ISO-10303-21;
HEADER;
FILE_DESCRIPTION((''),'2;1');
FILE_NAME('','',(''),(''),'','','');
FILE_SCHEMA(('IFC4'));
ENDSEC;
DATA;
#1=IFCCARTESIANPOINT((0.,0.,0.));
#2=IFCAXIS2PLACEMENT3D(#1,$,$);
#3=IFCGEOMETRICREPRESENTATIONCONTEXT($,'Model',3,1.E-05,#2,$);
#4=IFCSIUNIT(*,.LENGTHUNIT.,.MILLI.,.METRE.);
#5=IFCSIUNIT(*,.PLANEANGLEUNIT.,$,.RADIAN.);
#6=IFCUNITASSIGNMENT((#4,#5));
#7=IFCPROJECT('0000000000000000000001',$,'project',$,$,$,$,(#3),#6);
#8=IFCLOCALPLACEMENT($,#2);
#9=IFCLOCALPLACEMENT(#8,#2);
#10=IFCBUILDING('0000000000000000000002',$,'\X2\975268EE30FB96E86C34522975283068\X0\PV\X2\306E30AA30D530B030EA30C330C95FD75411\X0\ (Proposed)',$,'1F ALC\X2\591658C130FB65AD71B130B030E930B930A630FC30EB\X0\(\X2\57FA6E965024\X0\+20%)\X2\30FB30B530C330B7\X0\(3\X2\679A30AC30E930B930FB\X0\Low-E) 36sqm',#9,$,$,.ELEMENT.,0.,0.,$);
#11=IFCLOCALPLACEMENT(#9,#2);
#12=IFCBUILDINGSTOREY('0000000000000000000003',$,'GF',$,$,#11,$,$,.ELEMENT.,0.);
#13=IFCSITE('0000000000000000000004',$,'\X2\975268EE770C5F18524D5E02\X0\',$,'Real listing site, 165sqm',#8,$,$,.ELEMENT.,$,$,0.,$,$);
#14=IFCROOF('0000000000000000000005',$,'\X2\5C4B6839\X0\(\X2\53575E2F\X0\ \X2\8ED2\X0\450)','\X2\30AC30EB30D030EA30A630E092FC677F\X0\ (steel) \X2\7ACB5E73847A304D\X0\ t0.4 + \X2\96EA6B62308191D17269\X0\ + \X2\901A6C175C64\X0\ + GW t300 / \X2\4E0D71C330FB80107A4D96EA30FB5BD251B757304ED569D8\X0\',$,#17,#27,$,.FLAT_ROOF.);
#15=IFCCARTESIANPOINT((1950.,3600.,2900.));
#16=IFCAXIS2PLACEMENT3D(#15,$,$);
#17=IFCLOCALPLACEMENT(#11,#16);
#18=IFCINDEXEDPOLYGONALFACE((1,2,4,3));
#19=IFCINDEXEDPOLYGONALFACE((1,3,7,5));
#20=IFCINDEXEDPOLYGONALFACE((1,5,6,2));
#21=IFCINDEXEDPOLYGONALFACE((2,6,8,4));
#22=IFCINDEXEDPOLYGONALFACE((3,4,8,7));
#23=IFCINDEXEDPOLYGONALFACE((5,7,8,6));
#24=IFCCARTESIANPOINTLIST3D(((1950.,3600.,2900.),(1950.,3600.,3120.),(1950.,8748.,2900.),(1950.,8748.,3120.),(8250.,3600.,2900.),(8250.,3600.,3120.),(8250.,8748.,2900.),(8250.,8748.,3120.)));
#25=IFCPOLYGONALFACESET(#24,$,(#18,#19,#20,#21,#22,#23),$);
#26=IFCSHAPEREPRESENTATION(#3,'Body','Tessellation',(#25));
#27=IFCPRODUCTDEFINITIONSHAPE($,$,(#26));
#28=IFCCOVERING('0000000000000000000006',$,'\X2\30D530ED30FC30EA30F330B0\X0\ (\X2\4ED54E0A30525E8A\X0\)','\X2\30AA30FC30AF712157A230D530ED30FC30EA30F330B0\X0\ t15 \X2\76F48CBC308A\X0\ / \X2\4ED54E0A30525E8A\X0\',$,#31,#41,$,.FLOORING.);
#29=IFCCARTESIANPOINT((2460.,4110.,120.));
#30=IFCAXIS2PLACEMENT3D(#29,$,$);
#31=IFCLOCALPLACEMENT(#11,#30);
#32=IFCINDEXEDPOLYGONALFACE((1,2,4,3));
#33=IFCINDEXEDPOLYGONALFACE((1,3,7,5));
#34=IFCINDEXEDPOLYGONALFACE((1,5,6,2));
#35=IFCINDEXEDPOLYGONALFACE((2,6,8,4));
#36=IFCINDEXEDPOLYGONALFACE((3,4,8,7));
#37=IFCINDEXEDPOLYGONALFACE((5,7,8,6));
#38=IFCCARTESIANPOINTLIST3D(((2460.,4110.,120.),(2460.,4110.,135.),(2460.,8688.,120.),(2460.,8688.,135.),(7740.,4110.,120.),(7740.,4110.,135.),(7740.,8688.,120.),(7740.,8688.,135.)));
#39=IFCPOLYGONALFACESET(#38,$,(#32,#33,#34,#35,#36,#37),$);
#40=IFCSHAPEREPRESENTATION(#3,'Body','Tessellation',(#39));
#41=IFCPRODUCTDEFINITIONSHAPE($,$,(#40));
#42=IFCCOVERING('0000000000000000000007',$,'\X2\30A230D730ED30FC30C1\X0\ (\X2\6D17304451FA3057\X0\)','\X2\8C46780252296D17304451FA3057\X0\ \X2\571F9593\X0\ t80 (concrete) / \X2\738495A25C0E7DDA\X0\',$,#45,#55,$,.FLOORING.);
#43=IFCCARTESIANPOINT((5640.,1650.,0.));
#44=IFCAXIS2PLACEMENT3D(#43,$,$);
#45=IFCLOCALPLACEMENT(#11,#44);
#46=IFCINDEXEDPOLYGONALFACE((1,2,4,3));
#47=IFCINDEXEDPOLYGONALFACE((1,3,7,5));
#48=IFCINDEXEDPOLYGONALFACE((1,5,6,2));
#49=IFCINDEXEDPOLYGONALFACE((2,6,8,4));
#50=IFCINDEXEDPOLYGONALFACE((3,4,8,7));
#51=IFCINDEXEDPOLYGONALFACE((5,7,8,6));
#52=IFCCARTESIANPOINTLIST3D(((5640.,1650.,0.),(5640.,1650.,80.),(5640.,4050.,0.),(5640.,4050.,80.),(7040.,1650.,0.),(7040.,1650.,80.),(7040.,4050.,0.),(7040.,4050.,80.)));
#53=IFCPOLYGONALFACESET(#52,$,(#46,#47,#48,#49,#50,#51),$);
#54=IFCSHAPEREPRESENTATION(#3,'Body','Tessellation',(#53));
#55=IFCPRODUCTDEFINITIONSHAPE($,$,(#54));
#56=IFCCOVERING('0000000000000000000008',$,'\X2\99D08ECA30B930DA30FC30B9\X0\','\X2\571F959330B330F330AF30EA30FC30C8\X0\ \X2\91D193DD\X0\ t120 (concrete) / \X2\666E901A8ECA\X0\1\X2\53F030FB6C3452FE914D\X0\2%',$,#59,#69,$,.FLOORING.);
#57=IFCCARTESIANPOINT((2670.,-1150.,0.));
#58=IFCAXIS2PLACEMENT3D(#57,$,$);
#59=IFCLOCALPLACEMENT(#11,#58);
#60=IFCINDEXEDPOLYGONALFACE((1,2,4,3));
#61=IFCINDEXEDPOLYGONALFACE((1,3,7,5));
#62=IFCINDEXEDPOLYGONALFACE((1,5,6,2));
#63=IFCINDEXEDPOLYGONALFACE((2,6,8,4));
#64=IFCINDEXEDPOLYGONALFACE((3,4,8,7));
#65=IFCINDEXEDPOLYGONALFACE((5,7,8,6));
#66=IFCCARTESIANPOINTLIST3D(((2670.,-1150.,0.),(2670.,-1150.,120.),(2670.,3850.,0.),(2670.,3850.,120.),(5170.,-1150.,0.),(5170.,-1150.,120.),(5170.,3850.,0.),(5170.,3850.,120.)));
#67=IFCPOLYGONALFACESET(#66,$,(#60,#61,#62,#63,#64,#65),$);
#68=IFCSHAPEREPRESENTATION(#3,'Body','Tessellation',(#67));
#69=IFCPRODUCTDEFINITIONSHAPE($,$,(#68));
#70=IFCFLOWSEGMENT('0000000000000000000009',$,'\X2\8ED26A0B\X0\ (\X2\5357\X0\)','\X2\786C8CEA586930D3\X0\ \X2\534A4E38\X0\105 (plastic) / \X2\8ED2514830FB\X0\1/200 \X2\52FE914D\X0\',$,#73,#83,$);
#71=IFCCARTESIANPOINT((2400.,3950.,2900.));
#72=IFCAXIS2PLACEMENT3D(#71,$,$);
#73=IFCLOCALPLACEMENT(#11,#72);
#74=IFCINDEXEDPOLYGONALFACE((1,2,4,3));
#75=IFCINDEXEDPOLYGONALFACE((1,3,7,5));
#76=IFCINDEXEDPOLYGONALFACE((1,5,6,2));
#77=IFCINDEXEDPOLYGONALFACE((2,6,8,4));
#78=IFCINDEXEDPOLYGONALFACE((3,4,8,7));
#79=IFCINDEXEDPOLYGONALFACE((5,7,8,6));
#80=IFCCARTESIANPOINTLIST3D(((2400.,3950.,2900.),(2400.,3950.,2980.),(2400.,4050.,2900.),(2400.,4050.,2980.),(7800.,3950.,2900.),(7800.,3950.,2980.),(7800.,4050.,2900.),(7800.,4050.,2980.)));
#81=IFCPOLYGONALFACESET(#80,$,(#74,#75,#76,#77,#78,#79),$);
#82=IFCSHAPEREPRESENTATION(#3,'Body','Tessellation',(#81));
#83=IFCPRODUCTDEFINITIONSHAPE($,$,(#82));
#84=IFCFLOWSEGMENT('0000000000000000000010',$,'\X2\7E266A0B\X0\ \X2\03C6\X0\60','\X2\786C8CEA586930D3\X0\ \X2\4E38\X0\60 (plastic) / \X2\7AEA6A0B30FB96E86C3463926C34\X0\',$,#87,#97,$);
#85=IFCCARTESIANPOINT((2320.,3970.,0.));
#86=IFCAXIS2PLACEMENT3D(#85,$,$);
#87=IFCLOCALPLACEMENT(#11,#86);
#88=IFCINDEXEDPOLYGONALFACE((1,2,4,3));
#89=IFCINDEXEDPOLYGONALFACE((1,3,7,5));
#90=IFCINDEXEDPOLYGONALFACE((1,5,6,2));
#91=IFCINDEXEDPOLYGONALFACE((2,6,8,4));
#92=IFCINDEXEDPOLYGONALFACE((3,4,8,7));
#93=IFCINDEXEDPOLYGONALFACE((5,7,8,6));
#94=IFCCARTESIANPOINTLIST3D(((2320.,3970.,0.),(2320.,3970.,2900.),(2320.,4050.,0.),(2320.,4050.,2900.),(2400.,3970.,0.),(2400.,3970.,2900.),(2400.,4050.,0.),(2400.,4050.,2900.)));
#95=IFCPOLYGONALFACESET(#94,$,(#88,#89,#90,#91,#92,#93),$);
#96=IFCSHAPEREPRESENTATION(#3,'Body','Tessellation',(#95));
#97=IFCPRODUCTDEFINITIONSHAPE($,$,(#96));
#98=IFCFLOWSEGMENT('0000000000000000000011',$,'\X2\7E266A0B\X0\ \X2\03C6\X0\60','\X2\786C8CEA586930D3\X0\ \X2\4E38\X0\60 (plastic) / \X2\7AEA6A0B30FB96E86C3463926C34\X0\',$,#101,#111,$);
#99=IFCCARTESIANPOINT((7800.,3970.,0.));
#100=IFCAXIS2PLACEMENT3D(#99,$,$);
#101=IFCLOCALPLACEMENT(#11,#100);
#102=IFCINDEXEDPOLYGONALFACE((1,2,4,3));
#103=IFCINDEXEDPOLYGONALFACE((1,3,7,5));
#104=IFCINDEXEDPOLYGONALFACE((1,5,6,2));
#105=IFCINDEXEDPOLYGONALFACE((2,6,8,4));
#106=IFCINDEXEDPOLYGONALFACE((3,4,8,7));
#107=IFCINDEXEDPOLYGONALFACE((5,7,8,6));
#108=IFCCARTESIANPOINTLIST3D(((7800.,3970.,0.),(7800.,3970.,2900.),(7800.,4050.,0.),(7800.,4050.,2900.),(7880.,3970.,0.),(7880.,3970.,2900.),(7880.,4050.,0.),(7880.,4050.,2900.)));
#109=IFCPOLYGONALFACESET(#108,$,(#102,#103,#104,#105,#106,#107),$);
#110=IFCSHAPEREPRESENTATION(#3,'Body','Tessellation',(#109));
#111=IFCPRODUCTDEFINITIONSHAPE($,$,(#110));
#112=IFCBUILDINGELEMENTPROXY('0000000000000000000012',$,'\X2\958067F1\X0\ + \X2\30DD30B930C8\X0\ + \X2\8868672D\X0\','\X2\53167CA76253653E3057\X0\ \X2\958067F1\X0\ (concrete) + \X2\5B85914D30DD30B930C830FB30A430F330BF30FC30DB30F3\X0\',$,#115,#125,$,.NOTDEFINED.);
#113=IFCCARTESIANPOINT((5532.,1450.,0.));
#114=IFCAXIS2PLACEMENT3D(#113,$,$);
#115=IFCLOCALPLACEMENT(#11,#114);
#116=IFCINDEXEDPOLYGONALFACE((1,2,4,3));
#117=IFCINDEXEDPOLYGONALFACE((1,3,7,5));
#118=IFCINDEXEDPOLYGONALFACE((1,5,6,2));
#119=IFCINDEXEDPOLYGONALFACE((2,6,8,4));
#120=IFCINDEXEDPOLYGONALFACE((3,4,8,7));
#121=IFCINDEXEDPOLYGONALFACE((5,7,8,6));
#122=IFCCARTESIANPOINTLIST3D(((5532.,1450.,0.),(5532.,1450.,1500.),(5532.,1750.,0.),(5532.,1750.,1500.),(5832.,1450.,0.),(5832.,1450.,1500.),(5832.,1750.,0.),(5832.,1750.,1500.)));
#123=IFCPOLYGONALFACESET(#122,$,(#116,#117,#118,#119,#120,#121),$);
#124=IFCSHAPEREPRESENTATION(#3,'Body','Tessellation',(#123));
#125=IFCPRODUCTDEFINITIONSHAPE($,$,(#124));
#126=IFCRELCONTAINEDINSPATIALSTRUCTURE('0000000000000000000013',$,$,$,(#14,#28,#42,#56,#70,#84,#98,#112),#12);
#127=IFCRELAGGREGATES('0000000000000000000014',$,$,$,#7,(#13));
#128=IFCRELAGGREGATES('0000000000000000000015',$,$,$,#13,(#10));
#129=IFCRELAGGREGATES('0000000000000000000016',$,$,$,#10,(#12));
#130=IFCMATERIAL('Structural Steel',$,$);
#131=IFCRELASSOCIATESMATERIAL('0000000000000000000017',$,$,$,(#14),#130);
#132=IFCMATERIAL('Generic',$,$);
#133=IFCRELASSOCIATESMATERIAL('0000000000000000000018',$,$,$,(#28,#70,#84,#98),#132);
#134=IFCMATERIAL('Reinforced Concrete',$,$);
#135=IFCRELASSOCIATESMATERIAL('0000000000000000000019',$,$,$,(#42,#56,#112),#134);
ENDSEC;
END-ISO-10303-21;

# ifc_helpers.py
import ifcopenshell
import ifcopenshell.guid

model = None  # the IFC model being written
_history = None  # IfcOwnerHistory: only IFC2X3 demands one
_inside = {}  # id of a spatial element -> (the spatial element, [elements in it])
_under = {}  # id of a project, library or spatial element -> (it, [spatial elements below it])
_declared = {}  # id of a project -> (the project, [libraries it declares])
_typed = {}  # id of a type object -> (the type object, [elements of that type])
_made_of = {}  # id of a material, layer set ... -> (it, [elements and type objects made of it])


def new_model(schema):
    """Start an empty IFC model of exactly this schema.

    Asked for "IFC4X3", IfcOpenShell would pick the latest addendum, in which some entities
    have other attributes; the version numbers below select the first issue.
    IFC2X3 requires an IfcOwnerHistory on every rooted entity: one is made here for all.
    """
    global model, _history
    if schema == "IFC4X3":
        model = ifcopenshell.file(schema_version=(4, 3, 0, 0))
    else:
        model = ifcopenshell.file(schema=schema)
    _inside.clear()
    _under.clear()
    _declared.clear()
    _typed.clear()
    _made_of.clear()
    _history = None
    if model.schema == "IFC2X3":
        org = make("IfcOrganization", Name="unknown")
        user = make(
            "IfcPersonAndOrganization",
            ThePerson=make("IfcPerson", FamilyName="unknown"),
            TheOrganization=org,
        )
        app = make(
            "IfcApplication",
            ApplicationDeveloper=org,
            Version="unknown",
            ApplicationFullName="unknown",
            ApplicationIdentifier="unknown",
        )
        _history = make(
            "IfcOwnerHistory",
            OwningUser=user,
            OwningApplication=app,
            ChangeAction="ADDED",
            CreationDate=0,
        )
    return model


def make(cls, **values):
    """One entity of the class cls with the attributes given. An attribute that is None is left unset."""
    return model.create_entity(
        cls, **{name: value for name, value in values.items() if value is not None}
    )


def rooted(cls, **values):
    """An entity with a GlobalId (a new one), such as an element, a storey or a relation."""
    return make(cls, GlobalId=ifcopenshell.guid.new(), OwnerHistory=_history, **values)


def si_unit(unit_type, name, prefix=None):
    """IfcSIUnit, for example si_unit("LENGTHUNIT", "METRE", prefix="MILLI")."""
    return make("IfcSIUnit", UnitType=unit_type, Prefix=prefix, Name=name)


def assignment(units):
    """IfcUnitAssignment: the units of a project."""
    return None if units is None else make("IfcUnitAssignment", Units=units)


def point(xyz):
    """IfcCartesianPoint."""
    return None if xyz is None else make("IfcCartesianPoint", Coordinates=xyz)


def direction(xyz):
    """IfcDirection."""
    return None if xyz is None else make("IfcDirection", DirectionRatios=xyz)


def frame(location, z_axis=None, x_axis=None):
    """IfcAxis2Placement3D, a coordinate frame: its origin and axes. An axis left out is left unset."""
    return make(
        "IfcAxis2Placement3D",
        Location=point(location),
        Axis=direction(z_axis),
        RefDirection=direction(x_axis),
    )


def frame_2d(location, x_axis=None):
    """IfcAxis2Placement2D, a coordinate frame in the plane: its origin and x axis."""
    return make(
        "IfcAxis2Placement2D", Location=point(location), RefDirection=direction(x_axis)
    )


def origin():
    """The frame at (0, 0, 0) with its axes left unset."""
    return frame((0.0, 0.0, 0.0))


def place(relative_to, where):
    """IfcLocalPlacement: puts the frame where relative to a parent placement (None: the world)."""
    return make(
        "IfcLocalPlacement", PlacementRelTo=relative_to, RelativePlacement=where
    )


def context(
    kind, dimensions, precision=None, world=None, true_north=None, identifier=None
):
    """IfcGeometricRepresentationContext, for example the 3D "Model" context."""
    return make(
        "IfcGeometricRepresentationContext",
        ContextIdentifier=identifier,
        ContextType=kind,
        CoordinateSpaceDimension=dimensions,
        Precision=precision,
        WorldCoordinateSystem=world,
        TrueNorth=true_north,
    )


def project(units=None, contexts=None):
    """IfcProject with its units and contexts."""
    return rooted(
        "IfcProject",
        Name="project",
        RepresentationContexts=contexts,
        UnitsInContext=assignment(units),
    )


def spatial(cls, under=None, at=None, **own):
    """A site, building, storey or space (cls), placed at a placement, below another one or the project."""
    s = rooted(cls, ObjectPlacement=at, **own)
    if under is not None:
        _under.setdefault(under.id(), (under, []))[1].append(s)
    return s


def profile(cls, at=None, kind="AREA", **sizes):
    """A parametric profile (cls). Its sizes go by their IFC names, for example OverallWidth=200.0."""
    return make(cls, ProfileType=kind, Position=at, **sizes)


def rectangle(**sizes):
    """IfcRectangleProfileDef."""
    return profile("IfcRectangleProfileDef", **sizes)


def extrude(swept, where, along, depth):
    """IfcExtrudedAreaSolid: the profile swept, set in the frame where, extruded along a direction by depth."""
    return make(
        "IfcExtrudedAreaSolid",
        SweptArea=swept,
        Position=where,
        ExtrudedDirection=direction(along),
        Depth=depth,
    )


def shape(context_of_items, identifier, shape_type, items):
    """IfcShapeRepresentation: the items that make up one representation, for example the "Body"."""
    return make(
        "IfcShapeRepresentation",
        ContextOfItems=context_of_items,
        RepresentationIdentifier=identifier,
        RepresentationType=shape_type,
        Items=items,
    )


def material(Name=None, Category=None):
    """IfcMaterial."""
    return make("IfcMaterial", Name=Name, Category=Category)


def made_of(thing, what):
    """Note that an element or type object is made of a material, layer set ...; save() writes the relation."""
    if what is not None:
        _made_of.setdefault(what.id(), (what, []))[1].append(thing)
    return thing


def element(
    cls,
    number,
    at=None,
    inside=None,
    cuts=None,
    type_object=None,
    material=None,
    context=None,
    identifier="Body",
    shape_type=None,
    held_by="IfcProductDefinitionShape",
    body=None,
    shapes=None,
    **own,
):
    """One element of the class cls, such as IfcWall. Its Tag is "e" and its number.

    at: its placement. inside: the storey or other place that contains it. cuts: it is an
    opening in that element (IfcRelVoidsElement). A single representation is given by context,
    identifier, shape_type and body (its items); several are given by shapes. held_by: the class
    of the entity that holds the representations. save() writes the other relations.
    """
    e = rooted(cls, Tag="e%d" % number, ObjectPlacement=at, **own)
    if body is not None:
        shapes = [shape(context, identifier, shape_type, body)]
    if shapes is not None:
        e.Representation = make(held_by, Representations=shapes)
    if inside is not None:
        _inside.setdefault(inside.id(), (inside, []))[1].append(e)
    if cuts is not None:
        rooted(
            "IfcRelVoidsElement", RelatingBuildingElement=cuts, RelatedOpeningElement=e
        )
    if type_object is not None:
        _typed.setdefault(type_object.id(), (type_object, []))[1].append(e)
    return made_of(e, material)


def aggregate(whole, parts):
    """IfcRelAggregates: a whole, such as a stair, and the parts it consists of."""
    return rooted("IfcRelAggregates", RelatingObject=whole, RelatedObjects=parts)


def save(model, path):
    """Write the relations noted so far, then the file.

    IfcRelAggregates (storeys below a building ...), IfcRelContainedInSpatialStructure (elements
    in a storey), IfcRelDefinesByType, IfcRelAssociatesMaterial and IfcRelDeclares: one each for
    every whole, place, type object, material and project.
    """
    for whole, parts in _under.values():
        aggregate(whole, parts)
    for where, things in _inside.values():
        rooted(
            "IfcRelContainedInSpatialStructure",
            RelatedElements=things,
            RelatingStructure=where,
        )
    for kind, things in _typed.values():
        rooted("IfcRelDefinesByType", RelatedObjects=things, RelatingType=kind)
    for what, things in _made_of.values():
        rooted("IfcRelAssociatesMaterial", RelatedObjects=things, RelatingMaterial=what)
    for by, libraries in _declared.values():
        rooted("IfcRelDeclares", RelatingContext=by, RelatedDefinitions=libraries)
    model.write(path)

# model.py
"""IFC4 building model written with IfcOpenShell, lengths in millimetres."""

from ifc_helpers import new_model, si_unit, frame, frame_2d, origin, place, context, project, spatial, rectangle, extrude, material, element, save


model = new_model("IFC4")

# Units and contexts
model_context = context("Model", 3, precision=1e-05, world=origin())
ifc_project = project(units=[si_unit("LENGTHUNIT", "METRE", prefix="MILLI"), si_unit("PLANEANGLEUNIT", "RADIAN")], contexts=[model_context])

# Site, building, storey
site_placement = place(None, origin())
site = spatial("IfcSite", under=ifc_project, at=site_placement, Name="青森県弘前市", ObjectType="Real listing site, 165sqm", CompositionType="ELEMENT", RefElevation=0.0)
building_placement = place(site_placement, origin())
building = spatial("IfcBuilding", under=site, at=building_placement, Name="青森・雨水利用とPVのオフグリッド志向 (Proposed)", ObjectType="1F ALC外壁・断熱グラスウール(基準値+20%)・サッシ(3枚ガラス・Low-E) 36sqm", CompositionType="ELEMENT", ElevationOfRefHeight=0.0, ElevationOfTerrain=0.0)
storey_placement = place(building_placement, origin())
storey = spatial("IfcBuildingStorey", under=building, at=storey_placement, Name="GF", CompositionType="ELEMENT", Elevation=0.0)

# Shared definitions
ifc_material_1 = material(Name="Reinforced Concrete")

# Roof
ifc_material_2 = material(Name="Structural Steel")
roof_placement = place(storey_placement, frame((1950.0, 3600.0, 2900.0)))
element("IfcRoof", 1, at=roof_placement, inside=storey, material=ifc_material_2, Name="屋根(南帯 軒450)", Description="ガルバリウム鋼板 (steel) 立平葺き t0.4 + 雪止め金物 + 通気層 + GW t300 / 不燃・耐積雪・寒冷地仕様", PredefinedType="FLAT_ROOF", context=model_context, shape_type="SweptSolid", body=[
    extrude(rectangle(XDim=6300.0, YDim=5148.0, at=frame_2d((3150.0, 2574.0))), frame((1950.0, 3600.0, 2900.0)), (0.0, 0.0, 1.0), 220.0),
])

# Coverings
ifc_material_3 = material(Name="Generic")
covering_1_placement = place(storey_placement, frame((2460.0, 4110.0, 120.0)))
element("IfcCovering", 2, at=covering_1_placement, inside=storey, material=ifc_material_3, Name="フローリング (仕上げ床)", Description="オーク無垢フローリング t15 直貼り / 仕上げ床", PredefinedType="FLOORING", context=model_context, shape_type="SweptSolid", body=[
    extrude(rectangle(XDim=5280.0, YDim=4578.0, at=frame_2d((2640.0, 2289.0))), frame((2460.0, 4110.0, 120.0)), (0.0, 0.0, 1.0), 15.0),
])
covering_2_placement = place(storey_placement, frame((5640.0, 1650.0, 0.0)))
element("IfcCovering", 3, at=covering_2_placement, inside=storey, material=ifc_material_1, Name="アプローチ (洗い出し)", Description="豆砂利洗い出し 土間 t80 (concrete) / 玄関導線", PredefinedType="FLOORING", context=model_context, shape_type="SweptSolid", body=[
    extrude(rectangle(XDim=1400.0, YDim=2400.0, at=frame_2d((700.0, 1200.0))), frame((5640.0, 1650.0, 0.0)), (0.0, 0.0, 1.0), 80.0),
])
covering_3_placement = place(storey_placement, frame((2670.0, -1150.0, 0.0)))
element("IfcCovering", 4, at=covering_3_placement, inside=storey, material=ifc_material_1, Name="駐車スペース", Description="土間コンクリート 金鏝 t120 (concrete) / 普通車1台・水勾配2%", PredefinedType="FLOORING", context=model_context, shape_type="SweptSolid", body=[
    extrude(rectangle(XDim=2500.0, YDim=5000.0, at=frame_2d((1250.0, 2500.0))), frame((2670.0, -1150.0, 0.0)), (0.0, 0.0, 1.0), 120.0),
])

# Flow segments
flow_segment_1_placement = place(storey_placement, frame((2400.0, 3950.0, 2900.0)))
element("IfcFlowSegment", 5, at=flow_segment_1_placement, inside=storey, material=ifc_material_3, Name="軒樋 (南)", Description="硬質塩ビ 半丸105 (plastic) / 軒先・1/200 勾配", context=model_context, shape_type="SweptSolid", body=[
    extrude(rectangle(XDim=5400.0, YDim=100.0, at=frame_2d((2700.0, 50.0))), frame((2400.0, 3950.0, 2900.0)), (0.0, 0.0, 1.0), 80.0),
])
flow_segment_2_placement = place(storey_placement, frame((2320.0, 3970.0, 0.0)))
element("IfcFlowSegment", 6, at=flow_segment_2_placement, inside=storey, material=ifc_material_3, Name="縦樋 φ60", Description="硬質塩ビ 丸60 (plastic) / 竪樋・雨水排水", context=model_context, shape_type="SweptSolid", body=[
    extrude(rectangle(XDim=80.0, YDim=80.0, at=frame_2d((40.0, 40.0))), frame((2320.0, 3970.0, 0.0)), (0.0, 0.0, 1.0), 2900.0),
])
flow_segment_3_placement = place(storey_placement, frame((7800.0, 3970.0, 0.0)))
element("IfcFlowSegment", 7, at=flow_segment_3_placement, inside=storey, material=ifc_material_3, Name="縦樋 φ60", Description="硬質塩ビ 丸60 (plastic) / 竪樋・雨水排水", context=model_context, shape_type="SweptSolid", body=[
    extrude(rectangle(XDim=80.0, YDim=80.0, at=frame_2d((40.0, 40.0))), frame((7800.0, 3970.0, 0.0)), (0.0, 0.0, 1.0), 2900.0),
])

# Building element proxy
proxy_placement = place(storey_placement, frame((5532.0, 1450.0, 0.0)))
element("IfcBuildingElementProxy", 8, at=proxy_placement, inside=storey, material=ifc_material_1, Name="門柱 + ポスト + 表札", Description="化粧打放し 門柱 (concrete) + 宅配ポスト・インターホン", PredefinedType="NOTDEFINED", context=model_context, shape_type="SweptSolid", body=[
    extrude(rectangle(XDim=300.0, YDim=300.0, at=frame_2d((150.0, 150.0))), frame((5532.0, 1450.0, 0.0)), (0.0, 0.0, 1.0), 1500.0),
])

save(model, "model.ifc")
